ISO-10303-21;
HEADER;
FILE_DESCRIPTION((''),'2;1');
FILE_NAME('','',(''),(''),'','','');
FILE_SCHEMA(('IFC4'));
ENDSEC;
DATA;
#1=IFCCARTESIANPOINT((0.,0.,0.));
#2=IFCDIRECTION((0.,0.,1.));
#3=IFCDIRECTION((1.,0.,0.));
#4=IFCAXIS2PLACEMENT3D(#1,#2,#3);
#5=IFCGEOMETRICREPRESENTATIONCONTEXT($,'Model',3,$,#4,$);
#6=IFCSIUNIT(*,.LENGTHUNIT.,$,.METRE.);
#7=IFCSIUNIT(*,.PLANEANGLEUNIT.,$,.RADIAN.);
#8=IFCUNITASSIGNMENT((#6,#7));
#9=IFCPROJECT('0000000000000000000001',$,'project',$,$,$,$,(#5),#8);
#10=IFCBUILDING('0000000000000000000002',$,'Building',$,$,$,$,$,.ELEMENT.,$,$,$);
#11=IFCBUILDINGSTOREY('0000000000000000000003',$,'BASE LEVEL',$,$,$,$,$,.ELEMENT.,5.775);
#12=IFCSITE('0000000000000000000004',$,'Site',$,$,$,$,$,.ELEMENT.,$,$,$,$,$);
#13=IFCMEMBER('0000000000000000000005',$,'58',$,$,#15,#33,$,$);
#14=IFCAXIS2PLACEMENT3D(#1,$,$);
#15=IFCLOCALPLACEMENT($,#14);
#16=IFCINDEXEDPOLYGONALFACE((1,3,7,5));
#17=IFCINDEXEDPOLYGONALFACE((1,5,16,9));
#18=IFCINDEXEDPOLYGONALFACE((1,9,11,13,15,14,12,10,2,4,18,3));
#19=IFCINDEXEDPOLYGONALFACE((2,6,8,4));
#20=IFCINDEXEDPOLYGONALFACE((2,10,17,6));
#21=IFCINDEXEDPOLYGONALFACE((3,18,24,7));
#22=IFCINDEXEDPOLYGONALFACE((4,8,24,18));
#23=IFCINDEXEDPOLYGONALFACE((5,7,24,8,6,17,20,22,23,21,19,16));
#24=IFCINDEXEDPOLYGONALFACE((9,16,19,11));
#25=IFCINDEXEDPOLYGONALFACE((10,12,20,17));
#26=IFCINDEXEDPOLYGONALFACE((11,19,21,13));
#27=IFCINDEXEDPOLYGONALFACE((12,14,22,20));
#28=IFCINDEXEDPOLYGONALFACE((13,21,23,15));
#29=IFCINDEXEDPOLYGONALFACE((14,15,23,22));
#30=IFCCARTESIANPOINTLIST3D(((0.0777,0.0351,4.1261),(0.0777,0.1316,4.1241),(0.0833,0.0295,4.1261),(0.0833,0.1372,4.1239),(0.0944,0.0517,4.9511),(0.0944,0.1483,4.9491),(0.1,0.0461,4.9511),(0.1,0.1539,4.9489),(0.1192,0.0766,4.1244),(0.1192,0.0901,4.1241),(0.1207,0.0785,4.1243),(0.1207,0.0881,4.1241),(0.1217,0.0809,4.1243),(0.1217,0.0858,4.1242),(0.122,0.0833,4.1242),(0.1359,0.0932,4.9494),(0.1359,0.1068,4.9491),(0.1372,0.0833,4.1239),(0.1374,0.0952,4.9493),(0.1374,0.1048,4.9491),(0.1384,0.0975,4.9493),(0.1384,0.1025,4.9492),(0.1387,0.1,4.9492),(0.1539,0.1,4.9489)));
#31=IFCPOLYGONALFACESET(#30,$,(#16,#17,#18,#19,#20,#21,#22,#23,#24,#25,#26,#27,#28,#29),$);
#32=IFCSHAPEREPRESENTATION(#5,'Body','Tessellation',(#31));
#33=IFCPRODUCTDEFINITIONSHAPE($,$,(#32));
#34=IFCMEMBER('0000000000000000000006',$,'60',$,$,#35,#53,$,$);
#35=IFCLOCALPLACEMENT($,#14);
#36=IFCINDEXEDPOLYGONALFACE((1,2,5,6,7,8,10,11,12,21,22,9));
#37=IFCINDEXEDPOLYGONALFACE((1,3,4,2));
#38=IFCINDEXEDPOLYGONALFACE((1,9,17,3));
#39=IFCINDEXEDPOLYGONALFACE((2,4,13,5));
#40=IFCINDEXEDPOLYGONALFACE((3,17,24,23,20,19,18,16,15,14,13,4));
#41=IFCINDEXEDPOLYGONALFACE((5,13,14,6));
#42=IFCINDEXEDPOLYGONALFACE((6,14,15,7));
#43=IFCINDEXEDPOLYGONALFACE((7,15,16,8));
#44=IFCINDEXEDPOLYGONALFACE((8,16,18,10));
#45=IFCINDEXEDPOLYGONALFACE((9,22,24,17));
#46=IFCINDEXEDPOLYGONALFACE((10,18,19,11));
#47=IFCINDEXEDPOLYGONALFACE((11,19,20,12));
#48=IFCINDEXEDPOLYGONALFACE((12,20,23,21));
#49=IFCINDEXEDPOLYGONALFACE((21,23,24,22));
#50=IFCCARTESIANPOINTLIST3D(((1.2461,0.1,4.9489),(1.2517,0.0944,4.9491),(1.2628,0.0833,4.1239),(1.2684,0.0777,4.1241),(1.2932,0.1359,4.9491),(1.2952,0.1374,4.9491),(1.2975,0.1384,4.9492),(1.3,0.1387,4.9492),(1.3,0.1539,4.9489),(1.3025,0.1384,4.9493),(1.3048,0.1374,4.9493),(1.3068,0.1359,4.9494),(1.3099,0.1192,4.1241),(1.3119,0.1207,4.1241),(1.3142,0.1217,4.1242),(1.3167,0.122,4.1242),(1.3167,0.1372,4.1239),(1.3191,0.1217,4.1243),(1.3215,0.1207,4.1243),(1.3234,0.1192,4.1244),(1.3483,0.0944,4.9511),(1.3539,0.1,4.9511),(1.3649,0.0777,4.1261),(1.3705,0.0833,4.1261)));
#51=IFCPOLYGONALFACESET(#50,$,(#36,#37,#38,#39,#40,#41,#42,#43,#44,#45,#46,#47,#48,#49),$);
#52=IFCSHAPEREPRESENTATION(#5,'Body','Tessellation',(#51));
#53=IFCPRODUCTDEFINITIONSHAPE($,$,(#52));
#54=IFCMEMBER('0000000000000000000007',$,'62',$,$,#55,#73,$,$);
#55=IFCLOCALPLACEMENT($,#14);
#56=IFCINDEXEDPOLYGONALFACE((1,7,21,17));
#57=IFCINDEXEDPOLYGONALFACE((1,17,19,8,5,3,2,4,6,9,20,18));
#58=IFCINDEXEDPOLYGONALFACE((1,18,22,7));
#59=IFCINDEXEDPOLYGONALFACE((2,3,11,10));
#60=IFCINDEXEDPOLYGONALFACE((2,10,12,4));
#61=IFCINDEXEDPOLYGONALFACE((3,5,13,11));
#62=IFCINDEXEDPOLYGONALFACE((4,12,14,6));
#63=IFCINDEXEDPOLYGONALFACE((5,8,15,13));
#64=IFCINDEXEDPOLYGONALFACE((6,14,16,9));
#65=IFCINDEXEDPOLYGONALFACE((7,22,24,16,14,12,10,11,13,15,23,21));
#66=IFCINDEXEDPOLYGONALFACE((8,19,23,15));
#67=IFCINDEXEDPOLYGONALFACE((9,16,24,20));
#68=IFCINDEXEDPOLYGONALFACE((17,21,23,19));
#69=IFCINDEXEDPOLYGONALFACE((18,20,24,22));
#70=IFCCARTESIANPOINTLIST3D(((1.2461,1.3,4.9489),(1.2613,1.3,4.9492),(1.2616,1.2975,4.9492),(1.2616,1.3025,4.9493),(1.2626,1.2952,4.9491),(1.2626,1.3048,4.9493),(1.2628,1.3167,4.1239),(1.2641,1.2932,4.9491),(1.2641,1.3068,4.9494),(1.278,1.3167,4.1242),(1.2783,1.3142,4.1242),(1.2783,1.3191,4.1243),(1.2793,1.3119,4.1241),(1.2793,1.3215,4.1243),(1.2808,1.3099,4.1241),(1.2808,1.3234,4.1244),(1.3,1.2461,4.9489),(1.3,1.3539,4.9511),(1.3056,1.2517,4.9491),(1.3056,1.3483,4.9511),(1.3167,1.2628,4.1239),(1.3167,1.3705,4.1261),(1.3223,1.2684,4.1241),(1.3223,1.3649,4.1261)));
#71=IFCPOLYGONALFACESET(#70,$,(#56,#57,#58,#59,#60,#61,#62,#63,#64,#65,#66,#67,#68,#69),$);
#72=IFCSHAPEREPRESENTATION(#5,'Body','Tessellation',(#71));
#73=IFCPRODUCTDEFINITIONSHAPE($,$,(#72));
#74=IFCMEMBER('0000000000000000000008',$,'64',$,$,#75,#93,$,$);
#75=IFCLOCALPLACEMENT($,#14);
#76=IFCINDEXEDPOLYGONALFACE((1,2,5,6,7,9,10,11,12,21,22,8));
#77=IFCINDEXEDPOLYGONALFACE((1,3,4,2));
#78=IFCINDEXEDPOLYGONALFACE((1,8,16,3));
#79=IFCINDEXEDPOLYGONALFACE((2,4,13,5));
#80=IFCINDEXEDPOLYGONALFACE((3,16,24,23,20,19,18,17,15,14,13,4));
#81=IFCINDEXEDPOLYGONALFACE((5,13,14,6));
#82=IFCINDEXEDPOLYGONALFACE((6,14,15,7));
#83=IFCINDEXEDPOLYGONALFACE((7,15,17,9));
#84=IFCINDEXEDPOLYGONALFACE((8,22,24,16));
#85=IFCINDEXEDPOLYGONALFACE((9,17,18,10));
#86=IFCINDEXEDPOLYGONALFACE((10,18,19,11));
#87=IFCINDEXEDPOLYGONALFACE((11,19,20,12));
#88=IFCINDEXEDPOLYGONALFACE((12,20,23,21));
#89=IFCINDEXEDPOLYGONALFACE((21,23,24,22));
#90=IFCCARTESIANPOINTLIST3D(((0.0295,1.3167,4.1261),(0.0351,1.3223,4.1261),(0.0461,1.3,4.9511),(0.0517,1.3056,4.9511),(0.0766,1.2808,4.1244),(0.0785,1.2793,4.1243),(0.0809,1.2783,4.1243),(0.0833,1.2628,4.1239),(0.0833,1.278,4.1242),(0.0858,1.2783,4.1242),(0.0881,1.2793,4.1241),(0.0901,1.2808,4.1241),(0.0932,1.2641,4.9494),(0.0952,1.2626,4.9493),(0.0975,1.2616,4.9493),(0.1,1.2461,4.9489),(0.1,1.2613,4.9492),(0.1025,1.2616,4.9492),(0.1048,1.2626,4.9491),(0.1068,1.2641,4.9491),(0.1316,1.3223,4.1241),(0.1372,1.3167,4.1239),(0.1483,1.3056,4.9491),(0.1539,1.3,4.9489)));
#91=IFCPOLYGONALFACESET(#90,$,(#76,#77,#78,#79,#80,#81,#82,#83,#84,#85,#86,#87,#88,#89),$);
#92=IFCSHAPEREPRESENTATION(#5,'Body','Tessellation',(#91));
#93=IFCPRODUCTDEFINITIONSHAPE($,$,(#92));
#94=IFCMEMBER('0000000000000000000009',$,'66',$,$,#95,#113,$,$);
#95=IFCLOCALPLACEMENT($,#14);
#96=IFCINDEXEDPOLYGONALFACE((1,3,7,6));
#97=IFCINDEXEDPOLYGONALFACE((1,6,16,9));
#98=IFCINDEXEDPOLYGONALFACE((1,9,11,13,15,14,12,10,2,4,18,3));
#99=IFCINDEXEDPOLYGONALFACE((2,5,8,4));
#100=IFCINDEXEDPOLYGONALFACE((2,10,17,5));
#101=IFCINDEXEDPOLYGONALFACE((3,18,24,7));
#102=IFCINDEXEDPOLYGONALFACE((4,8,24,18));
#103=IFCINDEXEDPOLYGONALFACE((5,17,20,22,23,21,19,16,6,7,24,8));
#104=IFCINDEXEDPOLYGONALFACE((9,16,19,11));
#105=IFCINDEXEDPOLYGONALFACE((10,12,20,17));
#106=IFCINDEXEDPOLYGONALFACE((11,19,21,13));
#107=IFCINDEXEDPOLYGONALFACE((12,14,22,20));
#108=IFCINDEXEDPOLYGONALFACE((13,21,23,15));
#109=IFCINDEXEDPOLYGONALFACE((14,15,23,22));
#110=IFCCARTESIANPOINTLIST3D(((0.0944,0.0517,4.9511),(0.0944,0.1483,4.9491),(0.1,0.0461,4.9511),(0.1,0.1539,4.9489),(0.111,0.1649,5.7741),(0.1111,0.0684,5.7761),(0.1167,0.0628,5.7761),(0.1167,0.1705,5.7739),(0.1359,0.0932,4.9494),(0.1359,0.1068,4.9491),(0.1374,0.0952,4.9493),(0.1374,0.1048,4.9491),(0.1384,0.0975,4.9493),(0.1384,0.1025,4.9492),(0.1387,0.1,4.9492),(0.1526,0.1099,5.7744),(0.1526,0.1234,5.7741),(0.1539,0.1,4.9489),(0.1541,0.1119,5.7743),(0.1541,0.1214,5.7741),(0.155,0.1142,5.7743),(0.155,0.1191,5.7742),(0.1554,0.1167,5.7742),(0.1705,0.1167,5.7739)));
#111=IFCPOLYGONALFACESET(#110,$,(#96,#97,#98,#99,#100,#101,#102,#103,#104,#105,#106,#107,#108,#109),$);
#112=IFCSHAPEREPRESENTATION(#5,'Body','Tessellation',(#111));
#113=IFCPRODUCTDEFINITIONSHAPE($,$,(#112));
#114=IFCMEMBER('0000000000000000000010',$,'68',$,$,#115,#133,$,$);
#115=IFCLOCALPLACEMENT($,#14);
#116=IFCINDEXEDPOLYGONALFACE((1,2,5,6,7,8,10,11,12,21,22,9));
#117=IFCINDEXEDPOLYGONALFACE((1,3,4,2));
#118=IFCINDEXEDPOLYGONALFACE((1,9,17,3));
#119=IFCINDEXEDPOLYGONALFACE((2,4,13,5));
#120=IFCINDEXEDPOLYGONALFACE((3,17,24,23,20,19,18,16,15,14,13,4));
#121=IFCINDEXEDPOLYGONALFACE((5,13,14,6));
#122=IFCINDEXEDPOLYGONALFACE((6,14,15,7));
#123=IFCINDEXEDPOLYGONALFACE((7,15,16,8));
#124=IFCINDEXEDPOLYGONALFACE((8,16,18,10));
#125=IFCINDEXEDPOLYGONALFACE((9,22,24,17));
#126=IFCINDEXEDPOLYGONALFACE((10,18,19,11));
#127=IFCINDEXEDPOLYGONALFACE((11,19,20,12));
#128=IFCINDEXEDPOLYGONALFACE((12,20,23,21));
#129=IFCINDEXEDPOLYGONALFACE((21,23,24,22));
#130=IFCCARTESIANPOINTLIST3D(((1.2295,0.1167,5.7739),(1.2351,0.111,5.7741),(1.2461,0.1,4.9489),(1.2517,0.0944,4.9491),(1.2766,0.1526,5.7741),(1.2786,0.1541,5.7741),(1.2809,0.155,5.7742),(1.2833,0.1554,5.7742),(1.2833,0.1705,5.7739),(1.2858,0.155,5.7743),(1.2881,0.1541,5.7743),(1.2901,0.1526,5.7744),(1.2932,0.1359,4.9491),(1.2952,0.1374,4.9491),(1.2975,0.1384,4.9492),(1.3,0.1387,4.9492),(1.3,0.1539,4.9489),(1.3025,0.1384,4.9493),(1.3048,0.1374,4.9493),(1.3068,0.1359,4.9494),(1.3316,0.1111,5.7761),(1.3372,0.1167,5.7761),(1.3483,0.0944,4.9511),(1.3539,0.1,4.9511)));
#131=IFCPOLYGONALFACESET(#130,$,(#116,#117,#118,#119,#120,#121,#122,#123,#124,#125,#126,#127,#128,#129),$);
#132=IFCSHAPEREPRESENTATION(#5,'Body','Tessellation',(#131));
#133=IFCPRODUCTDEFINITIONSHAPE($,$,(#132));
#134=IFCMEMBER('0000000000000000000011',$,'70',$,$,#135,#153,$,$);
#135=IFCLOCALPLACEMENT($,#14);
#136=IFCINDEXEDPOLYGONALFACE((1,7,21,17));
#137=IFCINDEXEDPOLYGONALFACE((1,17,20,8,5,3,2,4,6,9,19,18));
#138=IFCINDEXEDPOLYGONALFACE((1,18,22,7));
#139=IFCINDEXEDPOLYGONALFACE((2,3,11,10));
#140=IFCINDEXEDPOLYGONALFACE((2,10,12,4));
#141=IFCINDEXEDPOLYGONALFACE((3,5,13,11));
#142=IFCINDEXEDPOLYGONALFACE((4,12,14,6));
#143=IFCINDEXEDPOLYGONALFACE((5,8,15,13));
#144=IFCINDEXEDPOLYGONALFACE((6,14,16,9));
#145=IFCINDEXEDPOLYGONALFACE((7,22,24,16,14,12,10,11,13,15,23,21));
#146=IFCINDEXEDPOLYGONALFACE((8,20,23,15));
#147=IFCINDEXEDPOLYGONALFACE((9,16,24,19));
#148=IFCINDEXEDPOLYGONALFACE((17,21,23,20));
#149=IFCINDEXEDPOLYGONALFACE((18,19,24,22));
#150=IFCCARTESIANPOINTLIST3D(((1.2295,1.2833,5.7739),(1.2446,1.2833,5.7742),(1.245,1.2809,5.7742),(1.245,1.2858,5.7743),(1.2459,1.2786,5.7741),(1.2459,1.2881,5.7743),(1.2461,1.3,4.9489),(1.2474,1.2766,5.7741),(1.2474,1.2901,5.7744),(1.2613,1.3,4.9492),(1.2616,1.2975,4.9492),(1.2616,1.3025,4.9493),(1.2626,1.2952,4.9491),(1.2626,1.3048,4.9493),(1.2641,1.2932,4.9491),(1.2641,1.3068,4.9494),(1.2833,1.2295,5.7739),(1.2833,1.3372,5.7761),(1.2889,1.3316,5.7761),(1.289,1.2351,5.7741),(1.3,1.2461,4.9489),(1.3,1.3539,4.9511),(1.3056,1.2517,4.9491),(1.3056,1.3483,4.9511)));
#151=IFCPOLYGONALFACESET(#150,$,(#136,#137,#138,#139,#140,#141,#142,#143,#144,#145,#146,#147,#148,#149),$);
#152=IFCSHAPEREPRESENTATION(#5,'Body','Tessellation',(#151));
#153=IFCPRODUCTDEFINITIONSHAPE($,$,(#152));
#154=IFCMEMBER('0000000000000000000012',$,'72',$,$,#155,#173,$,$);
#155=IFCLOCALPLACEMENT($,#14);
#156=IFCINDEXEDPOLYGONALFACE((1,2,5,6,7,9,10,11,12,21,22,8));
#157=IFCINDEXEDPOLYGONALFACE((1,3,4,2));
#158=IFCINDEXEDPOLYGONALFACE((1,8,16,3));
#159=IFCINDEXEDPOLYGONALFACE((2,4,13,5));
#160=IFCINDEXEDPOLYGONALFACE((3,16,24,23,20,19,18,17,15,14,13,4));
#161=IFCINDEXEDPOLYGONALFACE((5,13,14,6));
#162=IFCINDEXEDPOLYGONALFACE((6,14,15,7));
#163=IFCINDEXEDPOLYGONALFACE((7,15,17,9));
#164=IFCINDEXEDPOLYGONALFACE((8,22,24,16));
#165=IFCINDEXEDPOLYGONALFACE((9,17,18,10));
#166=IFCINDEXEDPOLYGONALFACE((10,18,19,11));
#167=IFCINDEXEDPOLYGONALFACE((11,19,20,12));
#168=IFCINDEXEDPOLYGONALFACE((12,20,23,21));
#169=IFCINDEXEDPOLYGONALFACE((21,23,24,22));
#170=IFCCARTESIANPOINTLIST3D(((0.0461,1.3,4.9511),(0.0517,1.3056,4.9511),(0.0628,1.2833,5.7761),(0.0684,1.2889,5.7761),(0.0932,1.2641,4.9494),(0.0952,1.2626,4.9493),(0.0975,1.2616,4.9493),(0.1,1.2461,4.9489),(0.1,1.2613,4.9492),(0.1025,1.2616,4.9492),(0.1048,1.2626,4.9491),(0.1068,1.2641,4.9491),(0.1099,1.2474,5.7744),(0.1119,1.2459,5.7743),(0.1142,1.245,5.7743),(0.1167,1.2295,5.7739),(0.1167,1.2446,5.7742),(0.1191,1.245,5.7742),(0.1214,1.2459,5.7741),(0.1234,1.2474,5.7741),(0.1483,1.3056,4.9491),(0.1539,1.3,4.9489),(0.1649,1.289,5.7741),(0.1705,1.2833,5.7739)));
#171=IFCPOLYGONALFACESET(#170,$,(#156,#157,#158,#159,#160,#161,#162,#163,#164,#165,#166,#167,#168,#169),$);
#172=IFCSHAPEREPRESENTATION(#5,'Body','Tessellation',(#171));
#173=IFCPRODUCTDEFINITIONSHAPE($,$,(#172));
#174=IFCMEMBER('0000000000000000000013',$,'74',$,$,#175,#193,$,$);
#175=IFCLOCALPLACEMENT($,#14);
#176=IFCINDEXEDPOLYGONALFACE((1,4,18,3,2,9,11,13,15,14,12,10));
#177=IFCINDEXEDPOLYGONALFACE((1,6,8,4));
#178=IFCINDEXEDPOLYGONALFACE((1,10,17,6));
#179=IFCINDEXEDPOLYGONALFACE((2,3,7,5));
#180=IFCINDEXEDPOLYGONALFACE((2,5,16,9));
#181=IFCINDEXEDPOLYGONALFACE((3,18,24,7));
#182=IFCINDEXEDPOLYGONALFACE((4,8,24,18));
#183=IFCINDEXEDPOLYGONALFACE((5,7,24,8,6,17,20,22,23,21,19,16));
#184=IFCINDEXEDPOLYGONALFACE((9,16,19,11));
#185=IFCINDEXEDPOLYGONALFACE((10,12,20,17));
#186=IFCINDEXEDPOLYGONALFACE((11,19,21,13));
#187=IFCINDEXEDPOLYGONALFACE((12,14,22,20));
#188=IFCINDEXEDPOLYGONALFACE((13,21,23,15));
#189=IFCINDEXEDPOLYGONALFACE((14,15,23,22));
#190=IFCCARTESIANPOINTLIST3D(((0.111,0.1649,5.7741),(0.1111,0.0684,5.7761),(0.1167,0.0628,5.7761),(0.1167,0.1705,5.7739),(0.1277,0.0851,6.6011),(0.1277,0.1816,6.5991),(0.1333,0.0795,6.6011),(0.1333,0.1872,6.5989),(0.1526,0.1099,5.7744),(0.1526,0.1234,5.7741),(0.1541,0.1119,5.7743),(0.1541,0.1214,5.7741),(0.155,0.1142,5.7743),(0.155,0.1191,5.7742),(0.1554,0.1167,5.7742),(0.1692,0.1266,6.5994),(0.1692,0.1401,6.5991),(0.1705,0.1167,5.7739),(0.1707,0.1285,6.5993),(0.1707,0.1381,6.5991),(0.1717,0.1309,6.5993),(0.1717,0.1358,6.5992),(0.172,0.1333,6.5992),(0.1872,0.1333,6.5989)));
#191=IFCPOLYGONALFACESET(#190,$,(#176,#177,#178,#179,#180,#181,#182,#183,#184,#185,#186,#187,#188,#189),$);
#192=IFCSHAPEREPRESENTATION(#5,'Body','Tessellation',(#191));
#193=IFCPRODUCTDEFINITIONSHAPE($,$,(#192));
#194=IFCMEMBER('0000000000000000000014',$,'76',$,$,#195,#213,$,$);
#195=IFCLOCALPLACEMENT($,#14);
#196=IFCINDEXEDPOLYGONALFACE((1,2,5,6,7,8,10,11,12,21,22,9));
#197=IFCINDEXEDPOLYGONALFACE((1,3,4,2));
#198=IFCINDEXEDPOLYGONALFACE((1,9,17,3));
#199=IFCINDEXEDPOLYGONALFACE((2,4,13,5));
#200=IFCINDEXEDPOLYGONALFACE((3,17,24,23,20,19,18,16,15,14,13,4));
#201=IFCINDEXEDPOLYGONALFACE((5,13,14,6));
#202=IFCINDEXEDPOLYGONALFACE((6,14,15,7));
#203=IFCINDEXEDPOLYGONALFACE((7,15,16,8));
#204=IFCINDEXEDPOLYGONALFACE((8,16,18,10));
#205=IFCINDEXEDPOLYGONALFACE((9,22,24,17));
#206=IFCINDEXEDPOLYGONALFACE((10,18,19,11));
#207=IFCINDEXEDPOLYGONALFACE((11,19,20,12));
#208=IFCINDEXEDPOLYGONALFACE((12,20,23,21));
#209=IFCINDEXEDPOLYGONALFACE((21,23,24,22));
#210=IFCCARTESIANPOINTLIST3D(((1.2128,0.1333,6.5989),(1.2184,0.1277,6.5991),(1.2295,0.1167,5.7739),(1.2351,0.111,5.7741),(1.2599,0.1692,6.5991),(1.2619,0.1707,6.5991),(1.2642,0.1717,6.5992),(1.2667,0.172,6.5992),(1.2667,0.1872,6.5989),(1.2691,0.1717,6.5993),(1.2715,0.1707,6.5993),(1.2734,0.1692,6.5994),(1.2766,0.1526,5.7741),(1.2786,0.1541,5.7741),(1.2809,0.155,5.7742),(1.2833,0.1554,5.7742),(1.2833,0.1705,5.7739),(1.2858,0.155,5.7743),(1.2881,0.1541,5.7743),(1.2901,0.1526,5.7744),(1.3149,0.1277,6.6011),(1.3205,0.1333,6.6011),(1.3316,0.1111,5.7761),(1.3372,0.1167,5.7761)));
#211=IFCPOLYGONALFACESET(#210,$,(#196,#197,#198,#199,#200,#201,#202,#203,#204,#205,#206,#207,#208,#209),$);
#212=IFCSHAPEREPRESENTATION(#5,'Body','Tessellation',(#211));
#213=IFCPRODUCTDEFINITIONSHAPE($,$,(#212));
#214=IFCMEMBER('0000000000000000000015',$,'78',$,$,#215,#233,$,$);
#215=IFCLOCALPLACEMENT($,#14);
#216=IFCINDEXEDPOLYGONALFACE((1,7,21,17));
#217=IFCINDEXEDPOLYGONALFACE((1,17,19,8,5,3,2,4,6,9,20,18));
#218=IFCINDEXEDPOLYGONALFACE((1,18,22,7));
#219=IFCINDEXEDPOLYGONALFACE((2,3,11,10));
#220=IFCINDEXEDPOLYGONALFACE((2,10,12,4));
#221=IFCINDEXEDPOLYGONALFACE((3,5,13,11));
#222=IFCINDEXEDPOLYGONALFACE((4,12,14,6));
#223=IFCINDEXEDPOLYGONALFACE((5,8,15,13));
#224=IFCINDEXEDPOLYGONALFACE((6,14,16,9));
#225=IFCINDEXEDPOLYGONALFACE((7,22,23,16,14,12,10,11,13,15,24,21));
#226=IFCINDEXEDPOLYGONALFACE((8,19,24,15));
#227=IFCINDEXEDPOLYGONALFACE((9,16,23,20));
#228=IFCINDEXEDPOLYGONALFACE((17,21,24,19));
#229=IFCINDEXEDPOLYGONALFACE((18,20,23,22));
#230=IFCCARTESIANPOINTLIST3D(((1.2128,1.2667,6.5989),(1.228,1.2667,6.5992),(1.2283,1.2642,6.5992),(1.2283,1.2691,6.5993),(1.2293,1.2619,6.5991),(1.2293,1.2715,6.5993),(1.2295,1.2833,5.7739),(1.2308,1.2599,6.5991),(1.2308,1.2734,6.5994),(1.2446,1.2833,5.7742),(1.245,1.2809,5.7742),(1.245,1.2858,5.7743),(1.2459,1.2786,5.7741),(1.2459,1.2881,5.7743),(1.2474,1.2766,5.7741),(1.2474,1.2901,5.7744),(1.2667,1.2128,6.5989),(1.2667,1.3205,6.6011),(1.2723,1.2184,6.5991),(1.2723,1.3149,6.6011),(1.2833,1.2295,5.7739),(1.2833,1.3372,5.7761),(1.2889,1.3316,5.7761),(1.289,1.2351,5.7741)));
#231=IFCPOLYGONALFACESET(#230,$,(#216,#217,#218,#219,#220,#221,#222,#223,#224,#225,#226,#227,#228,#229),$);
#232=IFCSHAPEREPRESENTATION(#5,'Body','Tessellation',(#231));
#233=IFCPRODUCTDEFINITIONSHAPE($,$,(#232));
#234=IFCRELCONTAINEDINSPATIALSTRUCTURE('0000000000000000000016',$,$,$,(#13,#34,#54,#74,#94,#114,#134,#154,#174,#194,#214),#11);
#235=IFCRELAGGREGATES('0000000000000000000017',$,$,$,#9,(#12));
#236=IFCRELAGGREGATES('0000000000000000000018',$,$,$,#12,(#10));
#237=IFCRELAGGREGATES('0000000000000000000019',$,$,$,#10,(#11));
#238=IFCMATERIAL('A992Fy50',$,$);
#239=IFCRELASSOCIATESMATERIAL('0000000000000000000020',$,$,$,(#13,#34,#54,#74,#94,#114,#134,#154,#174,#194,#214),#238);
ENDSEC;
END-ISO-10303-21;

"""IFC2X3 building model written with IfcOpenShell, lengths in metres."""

from ifc_helpers import new_model, si_unit, frame, origin_with_axes, origin_2d_with_axis, place, context, project, spatial, l_section, extrude, material, element, save


model = new_model("IFC2X3")

# Units and contexts
model_context = context("Model", 3, world=origin_with_axes())
ifc_project = project(units=[si_unit("LENGTHUNIT", "METRE"), si_unit("PLANEANGLEUNIT", "RADIAN")], contexts=[model_context])

# Site, building, storey
site = spatial("IfcSite", under=ifc_project, Name="Site", CompositionType="ELEMENT")
building = spatial("IfcBuilding", under=site, Name="Building", CompositionType="ELEMENT")
storey = spatial("IfcBuildingStorey", under=building, Name="BASE LEVEL", CompositionType="ELEMENT", Elevation=5.775)

# Members
ifc_material = material(Name="A992Fy50")
for number, where, z_axis, x_axis, name in (
    (1, (0.0833, 0.0833, 4.125), (0.020194, 0.020194, 0.999592), (-0.707107, 0.707107, 0.0), "58"),
    (2, (1.3167, 0.0833, 4.125), (-0.020194, 0.020194, 0.999592), (-0.707107, -0.707107, 0.0), "60"),
    (3, (1.3167, 1.3167, 4.125), (-0.020194, -0.020194, 0.999592), (0.707107, -0.707107, 0.0), "62"),
    (4, (0.0833, 1.3167, 4.125), (0.020194, -0.020194, 0.999592), (0.707107, 0.707107, 0.0), "64"),
    (5, (0.1, 0.1, 4.95), (0.020194, 0.020194, 0.999592), (-0.707107, 0.707107, 0.0), "66"),
    (6, (1.3, 0.1, 4.95), (-0.020194, 0.020194, 0.999592), (-0.707107, -0.707107, 0.0), "68"),
    (7, (1.3, 1.3, 4.95), (-0.020194, -0.020194, 0.999592), (0.707107, -0.707107, 0.0), "70"),
    (8, (0.1, 1.3, 4.95), (0.020194, -0.020194, 0.999592), (0.707107, 0.707107, 0.0), "72"),
    (9, (0.1167, 0.1167, 5.775), (0.020194, 0.020194, 0.999592), (-0.707107, 0.707107, 0.0), "74"),
    (10, (1.2833, 0.1167, 5.775), (-0.020194, 0.020194, 0.999592), (-0.707107, -0.707107, 0.0), "76"),
    (11, (1.2833, 1.2833, 5.775), (-0.020194, -0.020194, 0.999592), (0.707107, -0.707107, 0.0), "78"),
):
    element("IfcMember", number, at=place(None, frame(where, z_axis=z_axis, x_axis=x_axis)), inside=storey, material=ifc_material, Name=name, context=model_context, shape_type="SweptSolid", body=[
        extrude(l_section(Depth=0.0762, Width=0.0762, Thickness=0.0079, FilletRadius=0.0096, at=origin_2d_with_axis()), origin_with_axes(), (0.0, 0.0, 1.0), 0.8253),
    ])

save(model, "model.ifc")
